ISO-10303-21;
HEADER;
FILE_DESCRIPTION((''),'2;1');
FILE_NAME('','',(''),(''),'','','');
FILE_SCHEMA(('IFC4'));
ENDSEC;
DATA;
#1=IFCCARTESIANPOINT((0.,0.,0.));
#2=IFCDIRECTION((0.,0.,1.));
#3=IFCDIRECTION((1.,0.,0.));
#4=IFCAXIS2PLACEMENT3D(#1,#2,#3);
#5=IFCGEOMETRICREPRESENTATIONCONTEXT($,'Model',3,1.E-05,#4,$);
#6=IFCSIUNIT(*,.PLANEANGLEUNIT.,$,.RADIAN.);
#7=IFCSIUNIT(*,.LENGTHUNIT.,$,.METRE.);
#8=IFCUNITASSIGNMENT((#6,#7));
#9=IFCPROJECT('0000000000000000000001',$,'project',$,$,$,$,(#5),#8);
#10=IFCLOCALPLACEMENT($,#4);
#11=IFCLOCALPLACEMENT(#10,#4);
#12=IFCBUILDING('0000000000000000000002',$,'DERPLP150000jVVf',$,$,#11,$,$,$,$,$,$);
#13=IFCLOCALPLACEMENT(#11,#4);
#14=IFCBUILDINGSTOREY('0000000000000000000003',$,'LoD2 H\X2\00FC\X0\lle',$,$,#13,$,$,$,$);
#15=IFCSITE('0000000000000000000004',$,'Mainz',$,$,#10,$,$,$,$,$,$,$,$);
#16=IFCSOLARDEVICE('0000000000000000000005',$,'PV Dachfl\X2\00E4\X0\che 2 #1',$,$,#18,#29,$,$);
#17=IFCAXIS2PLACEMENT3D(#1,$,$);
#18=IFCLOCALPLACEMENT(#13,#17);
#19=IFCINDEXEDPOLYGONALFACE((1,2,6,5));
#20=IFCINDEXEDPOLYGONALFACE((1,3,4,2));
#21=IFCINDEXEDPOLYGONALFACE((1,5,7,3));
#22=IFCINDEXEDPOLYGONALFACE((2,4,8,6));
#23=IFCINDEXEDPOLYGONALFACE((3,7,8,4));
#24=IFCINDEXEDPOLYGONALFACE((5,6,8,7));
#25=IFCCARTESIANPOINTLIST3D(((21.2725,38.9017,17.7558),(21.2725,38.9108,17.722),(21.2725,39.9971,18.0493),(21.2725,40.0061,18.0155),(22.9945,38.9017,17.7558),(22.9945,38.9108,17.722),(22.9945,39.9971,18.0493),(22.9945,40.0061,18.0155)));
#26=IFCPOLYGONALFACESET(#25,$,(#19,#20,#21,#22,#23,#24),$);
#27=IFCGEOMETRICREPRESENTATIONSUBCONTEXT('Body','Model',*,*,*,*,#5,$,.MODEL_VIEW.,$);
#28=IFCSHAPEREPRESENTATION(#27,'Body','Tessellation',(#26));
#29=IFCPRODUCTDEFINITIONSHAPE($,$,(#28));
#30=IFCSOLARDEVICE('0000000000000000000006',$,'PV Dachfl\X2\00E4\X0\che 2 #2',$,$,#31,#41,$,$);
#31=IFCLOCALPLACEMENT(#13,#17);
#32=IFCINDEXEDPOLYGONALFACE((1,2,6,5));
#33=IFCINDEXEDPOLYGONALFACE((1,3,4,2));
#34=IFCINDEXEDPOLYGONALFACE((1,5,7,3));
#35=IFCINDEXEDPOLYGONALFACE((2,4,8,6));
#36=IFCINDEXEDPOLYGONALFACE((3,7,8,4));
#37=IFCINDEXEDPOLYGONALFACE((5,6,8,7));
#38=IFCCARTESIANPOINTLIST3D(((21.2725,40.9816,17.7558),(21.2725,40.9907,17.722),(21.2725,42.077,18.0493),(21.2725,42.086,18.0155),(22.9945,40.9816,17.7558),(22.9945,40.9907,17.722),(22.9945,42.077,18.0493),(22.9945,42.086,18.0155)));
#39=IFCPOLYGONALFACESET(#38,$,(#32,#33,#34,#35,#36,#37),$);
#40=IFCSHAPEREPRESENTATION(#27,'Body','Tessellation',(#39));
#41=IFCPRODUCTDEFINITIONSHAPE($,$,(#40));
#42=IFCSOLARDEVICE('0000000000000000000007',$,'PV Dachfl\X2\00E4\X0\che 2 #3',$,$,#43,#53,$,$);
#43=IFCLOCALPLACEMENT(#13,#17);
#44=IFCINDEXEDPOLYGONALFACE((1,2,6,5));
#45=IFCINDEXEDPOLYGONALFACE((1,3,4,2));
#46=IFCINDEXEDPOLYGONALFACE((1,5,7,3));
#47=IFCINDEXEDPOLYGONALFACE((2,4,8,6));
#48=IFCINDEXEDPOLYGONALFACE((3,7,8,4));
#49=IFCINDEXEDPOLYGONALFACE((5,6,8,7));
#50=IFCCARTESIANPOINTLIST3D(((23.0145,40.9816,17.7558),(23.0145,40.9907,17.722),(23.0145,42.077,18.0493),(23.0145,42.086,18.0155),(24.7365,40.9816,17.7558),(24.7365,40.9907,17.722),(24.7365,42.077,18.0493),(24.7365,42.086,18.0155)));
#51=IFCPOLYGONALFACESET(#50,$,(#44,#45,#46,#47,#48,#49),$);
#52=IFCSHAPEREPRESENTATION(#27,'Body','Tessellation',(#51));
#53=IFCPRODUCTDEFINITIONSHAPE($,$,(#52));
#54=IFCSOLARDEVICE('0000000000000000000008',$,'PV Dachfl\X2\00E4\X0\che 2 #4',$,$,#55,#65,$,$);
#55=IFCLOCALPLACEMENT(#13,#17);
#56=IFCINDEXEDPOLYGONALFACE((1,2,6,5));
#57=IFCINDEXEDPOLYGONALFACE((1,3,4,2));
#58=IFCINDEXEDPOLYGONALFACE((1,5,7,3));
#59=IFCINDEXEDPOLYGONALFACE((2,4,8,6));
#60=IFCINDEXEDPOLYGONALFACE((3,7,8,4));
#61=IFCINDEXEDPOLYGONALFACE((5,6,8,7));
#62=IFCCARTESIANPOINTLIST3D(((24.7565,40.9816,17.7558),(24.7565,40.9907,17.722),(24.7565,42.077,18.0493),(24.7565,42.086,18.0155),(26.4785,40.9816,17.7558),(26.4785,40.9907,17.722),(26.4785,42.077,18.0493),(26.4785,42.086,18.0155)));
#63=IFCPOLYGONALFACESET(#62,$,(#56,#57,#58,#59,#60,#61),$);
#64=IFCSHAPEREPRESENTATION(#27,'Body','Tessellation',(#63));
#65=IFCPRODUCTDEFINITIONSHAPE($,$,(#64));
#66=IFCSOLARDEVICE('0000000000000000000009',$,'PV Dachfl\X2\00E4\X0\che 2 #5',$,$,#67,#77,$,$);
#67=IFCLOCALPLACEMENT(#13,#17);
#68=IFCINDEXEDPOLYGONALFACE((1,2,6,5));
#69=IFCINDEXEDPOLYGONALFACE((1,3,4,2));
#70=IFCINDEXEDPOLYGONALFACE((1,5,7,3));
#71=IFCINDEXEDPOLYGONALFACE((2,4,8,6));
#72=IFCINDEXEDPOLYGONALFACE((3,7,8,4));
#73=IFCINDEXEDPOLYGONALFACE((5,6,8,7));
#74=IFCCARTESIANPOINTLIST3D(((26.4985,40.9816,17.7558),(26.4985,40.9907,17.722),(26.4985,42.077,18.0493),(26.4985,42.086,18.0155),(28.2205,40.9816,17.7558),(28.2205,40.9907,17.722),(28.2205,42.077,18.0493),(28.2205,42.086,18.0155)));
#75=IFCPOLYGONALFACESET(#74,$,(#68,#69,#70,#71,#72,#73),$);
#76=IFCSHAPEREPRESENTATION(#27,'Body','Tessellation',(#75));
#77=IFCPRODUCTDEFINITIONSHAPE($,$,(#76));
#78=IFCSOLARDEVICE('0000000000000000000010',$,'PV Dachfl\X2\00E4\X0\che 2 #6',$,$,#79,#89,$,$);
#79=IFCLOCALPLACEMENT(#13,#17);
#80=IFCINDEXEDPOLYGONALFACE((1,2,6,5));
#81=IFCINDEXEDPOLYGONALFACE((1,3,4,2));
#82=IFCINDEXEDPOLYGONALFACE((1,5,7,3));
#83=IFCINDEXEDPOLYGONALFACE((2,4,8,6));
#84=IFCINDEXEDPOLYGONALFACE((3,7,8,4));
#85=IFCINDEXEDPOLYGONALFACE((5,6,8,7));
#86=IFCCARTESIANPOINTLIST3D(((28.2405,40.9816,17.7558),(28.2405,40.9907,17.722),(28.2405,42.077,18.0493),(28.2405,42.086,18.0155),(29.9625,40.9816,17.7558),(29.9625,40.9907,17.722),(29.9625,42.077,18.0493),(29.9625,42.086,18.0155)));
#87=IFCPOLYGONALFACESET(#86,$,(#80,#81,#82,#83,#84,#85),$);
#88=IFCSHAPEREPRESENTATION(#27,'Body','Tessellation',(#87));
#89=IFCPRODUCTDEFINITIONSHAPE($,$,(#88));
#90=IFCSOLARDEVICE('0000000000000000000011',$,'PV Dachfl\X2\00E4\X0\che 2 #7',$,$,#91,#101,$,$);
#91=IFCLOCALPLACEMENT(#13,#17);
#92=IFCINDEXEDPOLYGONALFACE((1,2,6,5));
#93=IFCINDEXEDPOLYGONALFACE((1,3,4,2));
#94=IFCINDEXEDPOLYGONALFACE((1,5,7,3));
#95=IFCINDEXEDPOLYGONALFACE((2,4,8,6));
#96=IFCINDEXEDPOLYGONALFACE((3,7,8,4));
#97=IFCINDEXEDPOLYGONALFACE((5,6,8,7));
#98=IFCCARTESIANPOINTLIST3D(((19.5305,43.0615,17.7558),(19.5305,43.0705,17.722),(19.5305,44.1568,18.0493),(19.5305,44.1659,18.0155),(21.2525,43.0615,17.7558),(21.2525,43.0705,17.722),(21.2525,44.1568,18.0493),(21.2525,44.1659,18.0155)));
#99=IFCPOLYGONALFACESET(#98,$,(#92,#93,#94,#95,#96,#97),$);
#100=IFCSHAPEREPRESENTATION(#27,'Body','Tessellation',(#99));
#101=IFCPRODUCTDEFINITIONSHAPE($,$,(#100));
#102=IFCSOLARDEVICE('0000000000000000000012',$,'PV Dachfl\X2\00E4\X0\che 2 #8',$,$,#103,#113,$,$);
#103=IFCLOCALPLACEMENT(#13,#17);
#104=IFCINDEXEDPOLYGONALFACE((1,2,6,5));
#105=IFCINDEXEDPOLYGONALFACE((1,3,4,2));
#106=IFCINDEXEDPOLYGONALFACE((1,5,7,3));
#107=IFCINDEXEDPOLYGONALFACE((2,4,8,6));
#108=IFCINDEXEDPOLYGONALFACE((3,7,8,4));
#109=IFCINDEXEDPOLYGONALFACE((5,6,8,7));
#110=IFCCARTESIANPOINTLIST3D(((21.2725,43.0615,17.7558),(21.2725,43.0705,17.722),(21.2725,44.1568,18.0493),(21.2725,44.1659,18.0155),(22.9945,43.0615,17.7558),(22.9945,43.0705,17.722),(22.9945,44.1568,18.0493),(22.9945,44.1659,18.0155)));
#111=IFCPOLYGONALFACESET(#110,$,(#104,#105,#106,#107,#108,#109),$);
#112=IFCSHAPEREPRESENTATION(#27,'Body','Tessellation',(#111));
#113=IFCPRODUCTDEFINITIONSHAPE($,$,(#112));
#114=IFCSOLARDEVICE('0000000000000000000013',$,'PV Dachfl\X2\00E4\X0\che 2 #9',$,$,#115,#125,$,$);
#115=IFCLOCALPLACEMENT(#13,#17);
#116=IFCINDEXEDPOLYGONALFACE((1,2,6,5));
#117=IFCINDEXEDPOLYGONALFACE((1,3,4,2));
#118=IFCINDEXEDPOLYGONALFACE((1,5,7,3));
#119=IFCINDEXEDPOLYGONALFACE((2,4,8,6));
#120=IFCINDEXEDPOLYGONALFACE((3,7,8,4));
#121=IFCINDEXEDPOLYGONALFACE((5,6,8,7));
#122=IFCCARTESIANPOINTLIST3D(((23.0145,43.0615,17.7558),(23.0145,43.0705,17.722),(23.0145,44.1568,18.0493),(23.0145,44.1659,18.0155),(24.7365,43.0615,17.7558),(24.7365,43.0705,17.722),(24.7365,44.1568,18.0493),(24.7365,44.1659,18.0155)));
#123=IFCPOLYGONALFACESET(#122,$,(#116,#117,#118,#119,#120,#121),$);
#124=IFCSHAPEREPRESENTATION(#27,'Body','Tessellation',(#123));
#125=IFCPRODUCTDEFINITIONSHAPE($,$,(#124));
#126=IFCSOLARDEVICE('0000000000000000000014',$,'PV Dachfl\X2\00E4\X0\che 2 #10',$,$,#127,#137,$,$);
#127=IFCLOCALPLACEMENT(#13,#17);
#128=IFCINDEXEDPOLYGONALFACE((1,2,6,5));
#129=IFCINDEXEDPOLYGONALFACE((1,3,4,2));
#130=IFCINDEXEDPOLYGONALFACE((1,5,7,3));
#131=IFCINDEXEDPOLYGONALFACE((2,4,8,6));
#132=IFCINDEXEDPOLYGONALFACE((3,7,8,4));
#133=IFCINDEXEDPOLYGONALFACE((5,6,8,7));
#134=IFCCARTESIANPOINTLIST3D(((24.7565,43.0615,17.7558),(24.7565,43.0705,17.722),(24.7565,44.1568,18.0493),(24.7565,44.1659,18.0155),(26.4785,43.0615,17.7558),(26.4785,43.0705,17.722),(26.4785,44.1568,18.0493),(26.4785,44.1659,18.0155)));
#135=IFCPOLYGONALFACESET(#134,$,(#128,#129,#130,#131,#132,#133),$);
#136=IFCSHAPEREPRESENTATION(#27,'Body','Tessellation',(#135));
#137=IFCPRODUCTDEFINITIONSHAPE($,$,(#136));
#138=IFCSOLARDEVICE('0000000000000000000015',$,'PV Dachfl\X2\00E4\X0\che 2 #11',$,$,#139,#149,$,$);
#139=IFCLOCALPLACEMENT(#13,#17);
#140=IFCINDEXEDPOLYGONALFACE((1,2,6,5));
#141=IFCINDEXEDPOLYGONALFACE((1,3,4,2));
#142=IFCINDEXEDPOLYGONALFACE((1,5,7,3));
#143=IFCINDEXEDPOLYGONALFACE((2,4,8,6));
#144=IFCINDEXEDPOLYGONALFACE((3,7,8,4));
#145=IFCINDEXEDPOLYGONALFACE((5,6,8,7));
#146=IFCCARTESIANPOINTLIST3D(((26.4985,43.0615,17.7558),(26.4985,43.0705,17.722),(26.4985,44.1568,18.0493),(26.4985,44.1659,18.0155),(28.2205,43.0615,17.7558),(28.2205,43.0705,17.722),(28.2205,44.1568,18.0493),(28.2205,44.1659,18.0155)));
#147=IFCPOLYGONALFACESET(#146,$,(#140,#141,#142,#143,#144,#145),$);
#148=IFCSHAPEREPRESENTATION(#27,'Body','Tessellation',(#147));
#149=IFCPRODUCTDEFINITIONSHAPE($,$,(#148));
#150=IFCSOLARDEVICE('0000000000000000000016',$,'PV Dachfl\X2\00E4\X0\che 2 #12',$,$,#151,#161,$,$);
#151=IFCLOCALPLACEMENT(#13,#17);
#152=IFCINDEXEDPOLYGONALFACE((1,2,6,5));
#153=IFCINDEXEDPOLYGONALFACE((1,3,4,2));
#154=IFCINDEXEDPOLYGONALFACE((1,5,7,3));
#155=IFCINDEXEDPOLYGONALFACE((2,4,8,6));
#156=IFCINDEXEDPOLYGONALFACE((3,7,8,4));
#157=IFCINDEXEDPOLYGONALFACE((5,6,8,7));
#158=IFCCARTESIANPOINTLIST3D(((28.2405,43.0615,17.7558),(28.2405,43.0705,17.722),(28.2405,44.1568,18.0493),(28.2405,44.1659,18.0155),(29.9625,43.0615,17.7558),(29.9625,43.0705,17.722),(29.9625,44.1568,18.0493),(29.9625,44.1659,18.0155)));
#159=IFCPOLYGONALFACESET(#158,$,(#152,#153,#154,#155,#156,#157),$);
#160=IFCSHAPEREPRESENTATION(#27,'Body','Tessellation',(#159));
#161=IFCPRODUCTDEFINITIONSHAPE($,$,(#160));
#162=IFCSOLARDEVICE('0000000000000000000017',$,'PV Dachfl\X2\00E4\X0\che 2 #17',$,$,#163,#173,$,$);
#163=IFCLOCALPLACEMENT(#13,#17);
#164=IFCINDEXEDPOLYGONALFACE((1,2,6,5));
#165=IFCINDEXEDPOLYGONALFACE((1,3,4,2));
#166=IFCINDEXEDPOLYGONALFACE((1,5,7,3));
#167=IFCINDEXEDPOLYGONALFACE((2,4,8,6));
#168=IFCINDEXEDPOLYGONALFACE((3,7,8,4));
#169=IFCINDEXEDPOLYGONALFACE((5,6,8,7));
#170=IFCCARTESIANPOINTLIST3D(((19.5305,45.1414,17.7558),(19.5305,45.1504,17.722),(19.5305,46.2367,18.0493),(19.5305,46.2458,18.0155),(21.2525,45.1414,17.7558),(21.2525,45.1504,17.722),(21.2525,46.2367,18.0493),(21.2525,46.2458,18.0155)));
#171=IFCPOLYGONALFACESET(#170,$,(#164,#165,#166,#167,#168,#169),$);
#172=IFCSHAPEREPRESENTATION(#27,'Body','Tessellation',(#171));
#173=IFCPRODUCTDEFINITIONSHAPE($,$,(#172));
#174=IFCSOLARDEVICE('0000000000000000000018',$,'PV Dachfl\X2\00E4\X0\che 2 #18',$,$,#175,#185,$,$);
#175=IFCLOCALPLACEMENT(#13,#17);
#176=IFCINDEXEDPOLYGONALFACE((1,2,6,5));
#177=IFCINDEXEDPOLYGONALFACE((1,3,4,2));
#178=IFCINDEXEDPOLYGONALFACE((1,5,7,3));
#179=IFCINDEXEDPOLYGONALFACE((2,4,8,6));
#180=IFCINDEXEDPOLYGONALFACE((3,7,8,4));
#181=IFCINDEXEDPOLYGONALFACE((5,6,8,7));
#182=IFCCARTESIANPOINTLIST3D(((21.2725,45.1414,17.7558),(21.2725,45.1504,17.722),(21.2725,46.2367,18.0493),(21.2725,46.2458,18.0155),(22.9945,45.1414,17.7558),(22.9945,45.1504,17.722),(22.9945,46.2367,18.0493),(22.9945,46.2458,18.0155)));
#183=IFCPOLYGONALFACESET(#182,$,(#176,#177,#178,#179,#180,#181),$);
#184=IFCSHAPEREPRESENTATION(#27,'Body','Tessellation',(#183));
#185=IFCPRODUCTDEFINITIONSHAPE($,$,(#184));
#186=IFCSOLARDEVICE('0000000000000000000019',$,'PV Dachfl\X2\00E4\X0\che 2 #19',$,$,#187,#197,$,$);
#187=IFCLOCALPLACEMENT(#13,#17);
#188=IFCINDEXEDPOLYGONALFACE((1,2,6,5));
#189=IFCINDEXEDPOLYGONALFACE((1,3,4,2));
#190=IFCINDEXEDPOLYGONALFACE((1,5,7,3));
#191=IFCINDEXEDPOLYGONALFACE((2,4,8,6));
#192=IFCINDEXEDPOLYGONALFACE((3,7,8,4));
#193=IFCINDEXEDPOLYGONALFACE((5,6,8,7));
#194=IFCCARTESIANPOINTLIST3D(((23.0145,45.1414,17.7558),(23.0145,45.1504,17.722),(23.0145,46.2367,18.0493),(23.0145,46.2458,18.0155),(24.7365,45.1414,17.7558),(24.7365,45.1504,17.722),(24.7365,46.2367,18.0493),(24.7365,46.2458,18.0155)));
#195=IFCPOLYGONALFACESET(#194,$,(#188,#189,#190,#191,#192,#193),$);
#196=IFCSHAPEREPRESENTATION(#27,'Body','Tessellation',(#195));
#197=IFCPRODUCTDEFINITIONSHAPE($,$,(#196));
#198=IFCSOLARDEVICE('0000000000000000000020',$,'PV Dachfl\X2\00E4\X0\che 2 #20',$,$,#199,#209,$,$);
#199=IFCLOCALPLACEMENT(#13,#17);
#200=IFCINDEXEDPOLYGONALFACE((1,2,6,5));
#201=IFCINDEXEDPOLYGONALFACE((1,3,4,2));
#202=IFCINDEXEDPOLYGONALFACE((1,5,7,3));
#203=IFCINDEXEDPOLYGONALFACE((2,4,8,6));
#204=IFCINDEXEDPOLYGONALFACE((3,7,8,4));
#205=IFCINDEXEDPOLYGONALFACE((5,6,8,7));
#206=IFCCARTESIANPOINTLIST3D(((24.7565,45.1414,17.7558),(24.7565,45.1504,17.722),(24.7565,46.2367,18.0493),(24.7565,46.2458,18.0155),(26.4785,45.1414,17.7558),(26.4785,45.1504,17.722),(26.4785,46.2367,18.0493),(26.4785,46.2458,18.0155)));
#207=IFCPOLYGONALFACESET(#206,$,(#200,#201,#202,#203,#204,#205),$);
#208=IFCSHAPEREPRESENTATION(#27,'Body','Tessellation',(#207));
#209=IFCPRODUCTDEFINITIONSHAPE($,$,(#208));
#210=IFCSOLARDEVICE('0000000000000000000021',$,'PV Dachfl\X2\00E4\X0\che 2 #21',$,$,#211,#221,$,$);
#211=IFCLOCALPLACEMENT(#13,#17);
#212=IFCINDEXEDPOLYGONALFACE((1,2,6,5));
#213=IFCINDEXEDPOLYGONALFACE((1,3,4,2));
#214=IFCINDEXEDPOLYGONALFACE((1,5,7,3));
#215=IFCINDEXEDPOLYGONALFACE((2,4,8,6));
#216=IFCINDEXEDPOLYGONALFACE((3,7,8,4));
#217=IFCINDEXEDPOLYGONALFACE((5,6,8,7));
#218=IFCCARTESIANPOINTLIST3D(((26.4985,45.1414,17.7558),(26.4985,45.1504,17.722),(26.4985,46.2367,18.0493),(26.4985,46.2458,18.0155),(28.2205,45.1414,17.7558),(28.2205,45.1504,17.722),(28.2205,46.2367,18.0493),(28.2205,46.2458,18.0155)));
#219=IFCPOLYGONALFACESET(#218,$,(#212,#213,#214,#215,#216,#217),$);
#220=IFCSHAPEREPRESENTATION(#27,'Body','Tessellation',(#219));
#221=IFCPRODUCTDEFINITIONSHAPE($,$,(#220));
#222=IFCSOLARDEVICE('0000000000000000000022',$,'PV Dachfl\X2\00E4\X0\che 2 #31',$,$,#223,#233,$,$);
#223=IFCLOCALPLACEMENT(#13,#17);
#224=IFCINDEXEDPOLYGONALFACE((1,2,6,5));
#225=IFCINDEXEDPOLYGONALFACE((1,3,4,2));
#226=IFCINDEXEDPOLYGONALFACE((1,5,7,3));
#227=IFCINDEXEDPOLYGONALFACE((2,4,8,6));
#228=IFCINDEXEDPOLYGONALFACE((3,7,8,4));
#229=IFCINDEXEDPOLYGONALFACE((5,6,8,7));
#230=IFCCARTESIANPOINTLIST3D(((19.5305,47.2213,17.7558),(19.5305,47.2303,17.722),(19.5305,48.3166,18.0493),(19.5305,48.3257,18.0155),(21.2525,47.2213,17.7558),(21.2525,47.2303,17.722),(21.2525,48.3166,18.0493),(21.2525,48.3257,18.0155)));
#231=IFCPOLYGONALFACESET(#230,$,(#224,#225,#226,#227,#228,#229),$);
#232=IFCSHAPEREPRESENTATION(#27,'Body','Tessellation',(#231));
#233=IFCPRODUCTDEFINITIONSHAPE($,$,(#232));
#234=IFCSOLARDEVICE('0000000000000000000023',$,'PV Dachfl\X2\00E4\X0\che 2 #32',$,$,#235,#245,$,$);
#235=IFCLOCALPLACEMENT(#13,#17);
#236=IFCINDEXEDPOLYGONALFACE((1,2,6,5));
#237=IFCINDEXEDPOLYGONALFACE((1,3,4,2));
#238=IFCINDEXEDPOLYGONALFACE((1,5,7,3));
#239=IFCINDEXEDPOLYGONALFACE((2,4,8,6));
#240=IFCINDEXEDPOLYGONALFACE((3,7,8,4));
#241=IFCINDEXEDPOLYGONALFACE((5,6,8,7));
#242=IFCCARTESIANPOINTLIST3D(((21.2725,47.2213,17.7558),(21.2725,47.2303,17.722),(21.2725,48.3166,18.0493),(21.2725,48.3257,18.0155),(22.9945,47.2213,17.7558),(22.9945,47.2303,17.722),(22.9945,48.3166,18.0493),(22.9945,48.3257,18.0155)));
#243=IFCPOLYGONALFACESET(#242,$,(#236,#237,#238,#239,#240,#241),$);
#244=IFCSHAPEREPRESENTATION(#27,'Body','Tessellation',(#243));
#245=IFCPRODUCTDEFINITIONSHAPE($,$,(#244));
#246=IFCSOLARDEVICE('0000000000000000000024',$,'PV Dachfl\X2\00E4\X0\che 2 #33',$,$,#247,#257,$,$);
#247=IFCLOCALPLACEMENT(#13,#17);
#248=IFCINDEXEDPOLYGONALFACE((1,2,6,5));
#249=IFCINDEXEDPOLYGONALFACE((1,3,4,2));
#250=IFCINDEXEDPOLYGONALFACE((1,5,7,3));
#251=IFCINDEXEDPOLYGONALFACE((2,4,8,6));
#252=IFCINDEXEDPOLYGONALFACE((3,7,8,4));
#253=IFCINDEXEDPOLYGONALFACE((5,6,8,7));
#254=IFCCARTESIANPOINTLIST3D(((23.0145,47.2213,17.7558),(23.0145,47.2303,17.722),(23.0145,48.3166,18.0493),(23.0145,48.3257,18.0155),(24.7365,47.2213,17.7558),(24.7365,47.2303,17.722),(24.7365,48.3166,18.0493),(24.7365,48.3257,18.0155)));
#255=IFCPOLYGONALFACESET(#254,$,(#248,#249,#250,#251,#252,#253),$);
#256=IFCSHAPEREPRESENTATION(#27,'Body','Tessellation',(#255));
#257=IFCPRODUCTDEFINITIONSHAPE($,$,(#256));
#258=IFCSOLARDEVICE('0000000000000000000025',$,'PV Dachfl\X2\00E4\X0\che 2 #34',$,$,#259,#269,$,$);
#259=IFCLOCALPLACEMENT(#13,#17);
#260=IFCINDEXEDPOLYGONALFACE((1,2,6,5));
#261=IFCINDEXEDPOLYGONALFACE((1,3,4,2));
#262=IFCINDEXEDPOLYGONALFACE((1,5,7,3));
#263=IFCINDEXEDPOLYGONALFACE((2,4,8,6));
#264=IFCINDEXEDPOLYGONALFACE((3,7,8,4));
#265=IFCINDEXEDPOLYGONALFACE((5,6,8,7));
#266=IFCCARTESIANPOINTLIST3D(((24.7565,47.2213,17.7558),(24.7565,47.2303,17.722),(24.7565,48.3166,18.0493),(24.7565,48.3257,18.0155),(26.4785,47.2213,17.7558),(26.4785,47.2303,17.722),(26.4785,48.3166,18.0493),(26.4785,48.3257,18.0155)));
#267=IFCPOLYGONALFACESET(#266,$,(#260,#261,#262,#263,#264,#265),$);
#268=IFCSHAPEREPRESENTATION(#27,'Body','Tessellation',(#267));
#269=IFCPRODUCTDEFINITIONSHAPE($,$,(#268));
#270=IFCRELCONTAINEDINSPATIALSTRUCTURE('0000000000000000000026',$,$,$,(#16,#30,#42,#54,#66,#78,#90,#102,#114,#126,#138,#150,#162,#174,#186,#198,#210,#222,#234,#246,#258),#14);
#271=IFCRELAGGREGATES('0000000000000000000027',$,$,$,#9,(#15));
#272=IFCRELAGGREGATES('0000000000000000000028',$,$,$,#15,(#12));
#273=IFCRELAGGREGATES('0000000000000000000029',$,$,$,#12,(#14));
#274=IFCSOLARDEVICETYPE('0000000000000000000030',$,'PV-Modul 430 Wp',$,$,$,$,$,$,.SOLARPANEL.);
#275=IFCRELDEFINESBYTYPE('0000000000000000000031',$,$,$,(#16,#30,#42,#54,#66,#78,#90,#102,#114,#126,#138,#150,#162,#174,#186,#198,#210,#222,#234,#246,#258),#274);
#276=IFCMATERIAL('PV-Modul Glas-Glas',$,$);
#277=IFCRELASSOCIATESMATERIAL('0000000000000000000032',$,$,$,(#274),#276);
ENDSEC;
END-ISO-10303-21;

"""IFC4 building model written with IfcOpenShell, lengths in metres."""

from ifc_helpers import new_model, si_unit, frame, frame_2d, origin, origin_with_axes, place, context, subcontext, project, spatial, rectangle, extrude, source, transform, mapped, material, type_object, type_shapes, element, save


model = new_model("IFC4")

# Units and contexts
model_context = context("Model", 3, precision=1e-05, world=origin_with_axes())
body_context = subcontext(model_context, "Body", "Model", "MODEL_VIEW")
ifc_project = project(units=[si_unit("PLANEANGLEUNIT", "RADIAN"), si_unit("LENGTHUNIT", "METRE")], contexts=[model_context])

# Site, building, storey
site_placement = place(None, origin_with_axes())
site = spatial("IfcSite", under=ifc_project, at=site_placement, Name="Mainz")
building_placement = place(site_placement, origin_with_axes())
building = spatial("IfcBuilding", under=site, at=building_placement, Name="DERPLP150000jVVf")
storey_placement = place(building_placement, origin_with_axes())
storey = spatial("IfcBuildingStorey", under=building, at=storey_placement, Name="LoD2 Hülle")

# Solar devices
ifc_material = material(Name="PV-Modul Glas-Glas")
solar_device_type = type_object("IfcSolarDeviceType", Name="PV-Modul 430 Wp", PredefinedType="SOLARPANEL", material=ifc_material)
shared_shape = source(origin_with_axes(), body_context, "Body", "SweptSolid", [
    extrude(rectangle(XDim=1.722, YDim=1.134, at=frame_2d((0.861, 0.567))), origin(), (0.0, 0.0, 1.0), 0.035),
])
type_shapes(solar_device_type, [shared_shape])
for number, where, z_axis, x_axis, name in (
    (1, (21.2725, 38.9108, 17.722), (0.0, -0.258819, 0.965926), (1.0, 0.0, 0.0), "PV Dachfläche 2 #1"),
    (2, (21.2725, 40.9907, 17.722), (0.0, -0.258819, 0.965926), (1.0, 0.0, 0.0), "PV Dachfläche 2 #2"),
    (3, (23.0145, 40.9907, 17.722), (0.0, -0.258819, 0.965926), (1.0, 0.0, 0.0), "PV Dachfläche 2 #3"),
    (4, (24.7565, 40.9907, 17.722), (0.0, -0.258819, 0.965926), (1.0, 0.0, 0.0), "PV Dachfläche 2 #4"),
    (5, (26.4985, 40.9907, 17.722), (0.0, -0.258819, 0.965926), (1.0, 0.0, 0.0), "PV Dachfläche 2 #5"),
    (6, (28.2405, 40.9907, 17.722), (0.0, -0.258819, 0.965926), (1.0, 0.0, 0.0), "PV Dachfläche 2 #6"),
    (7, (19.5305, 43.0705, 17.722), (0.0, -0.258819, 0.965926), (1.0, 0.0, 0.0), "PV Dachfläche 2 #7"),
    (8, (21.2725, 43.0705, 17.722), (0.0, -0.258819, 0.965926), (1.0, 0.0, 0.0), "PV Dachfläche 2 #8"),
    (9, (23.0145, 43.0705, 17.722), (0.0, -0.258819, 0.965926), (1.0, 0.0, 0.0), "PV Dachfläche 2 #9"),
    (10, (24.7565, 43.0705, 17.722), (0.0, -0.258819, 0.965926), (1.0, 0.0, 0.0), "PV Dachfläche 2 #10"),
    (11, (26.4985, 43.0705, 17.722), (0.0, -0.258819, 0.965926), (1.0, 0.0, 0.0), "PV Dachfläche 2 #11"),
    (12, (28.2405, 43.0705, 17.722), (0.0, -0.258819, 0.965926), (1.0, 0.0, 0.0), "PV Dachfläche 2 #12"),
    (13, (19.5305, 45.1504, 17.722), (0.0, -0.258819, 0.965926), (1.0, 0.0, 0.0), "PV Dachfläche 2 #17"),
    (14, (21.2725, 45.1504, 17.722), (0.0, -0.258819, 0.965926), (1.0, 0.0, 0.0), "PV Dachfläche 2 #18"),
    (15, (23.0145, 45.1504, 17.722), (0.0, -0.258819, 0.965926), (1.0, 0.0, 0.0), "PV Dachfläche 2 #19"),
    (16, (24.7565, 45.1504, 17.722), (0.0, -0.258819, 0.965926), (1.0, 0.0, 0.0), "PV Dachfläche 2 #20"),
    (17, (26.4985, 45.1504, 17.722), (0.0, -0.258819, 0.965926), (1.0, 0.0, 0.0), "PV Dachfläche 2 #21"),
    (18, (19.5305, 47.2303, 17.722), (0.0, -0.258819, 0.965926), (1.0, 0.0, 0.0), "PV Dachfläche 2 #31"),
    (19, (21.2725, 47.2303, 17.722), (0.0, -0.258819, 0.965926), (1.0, 0.0, 0.0), "PV Dachfläche 2 #32"),
    (20, (23.0145, 47.2303, 17.722), (0.0, -0.258819, 0.965926), (1.0, 0.0, 0.0), "PV Dachfläche 2 #33"),
    (21, (24.7565, 47.2303, 17.722), (0.0, -0.258819, 0.965926), (1.0, 0.0, 0.0), "PV Dachfläche 2 #34"),
):
    element("IfcSolarDevice", number, at=place(storey_placement, frame(where, z_axis=z_axis, x_axis=x_axis)), inside=storey, type_object=solar_device_type, Name=name, context=body_context, shape_type="MappedRepresentation", body=[
        mapped(shared_shape, transform((0.0, 0.0, 0.0), x_axis=(1.0, 0.0, 0.0), y_axis=(0.0, 1.0, 0.0), z_axis=(0.0, 0.0, 1.0), scale=1.0)),
    ])

save(model, "model.ifc")
